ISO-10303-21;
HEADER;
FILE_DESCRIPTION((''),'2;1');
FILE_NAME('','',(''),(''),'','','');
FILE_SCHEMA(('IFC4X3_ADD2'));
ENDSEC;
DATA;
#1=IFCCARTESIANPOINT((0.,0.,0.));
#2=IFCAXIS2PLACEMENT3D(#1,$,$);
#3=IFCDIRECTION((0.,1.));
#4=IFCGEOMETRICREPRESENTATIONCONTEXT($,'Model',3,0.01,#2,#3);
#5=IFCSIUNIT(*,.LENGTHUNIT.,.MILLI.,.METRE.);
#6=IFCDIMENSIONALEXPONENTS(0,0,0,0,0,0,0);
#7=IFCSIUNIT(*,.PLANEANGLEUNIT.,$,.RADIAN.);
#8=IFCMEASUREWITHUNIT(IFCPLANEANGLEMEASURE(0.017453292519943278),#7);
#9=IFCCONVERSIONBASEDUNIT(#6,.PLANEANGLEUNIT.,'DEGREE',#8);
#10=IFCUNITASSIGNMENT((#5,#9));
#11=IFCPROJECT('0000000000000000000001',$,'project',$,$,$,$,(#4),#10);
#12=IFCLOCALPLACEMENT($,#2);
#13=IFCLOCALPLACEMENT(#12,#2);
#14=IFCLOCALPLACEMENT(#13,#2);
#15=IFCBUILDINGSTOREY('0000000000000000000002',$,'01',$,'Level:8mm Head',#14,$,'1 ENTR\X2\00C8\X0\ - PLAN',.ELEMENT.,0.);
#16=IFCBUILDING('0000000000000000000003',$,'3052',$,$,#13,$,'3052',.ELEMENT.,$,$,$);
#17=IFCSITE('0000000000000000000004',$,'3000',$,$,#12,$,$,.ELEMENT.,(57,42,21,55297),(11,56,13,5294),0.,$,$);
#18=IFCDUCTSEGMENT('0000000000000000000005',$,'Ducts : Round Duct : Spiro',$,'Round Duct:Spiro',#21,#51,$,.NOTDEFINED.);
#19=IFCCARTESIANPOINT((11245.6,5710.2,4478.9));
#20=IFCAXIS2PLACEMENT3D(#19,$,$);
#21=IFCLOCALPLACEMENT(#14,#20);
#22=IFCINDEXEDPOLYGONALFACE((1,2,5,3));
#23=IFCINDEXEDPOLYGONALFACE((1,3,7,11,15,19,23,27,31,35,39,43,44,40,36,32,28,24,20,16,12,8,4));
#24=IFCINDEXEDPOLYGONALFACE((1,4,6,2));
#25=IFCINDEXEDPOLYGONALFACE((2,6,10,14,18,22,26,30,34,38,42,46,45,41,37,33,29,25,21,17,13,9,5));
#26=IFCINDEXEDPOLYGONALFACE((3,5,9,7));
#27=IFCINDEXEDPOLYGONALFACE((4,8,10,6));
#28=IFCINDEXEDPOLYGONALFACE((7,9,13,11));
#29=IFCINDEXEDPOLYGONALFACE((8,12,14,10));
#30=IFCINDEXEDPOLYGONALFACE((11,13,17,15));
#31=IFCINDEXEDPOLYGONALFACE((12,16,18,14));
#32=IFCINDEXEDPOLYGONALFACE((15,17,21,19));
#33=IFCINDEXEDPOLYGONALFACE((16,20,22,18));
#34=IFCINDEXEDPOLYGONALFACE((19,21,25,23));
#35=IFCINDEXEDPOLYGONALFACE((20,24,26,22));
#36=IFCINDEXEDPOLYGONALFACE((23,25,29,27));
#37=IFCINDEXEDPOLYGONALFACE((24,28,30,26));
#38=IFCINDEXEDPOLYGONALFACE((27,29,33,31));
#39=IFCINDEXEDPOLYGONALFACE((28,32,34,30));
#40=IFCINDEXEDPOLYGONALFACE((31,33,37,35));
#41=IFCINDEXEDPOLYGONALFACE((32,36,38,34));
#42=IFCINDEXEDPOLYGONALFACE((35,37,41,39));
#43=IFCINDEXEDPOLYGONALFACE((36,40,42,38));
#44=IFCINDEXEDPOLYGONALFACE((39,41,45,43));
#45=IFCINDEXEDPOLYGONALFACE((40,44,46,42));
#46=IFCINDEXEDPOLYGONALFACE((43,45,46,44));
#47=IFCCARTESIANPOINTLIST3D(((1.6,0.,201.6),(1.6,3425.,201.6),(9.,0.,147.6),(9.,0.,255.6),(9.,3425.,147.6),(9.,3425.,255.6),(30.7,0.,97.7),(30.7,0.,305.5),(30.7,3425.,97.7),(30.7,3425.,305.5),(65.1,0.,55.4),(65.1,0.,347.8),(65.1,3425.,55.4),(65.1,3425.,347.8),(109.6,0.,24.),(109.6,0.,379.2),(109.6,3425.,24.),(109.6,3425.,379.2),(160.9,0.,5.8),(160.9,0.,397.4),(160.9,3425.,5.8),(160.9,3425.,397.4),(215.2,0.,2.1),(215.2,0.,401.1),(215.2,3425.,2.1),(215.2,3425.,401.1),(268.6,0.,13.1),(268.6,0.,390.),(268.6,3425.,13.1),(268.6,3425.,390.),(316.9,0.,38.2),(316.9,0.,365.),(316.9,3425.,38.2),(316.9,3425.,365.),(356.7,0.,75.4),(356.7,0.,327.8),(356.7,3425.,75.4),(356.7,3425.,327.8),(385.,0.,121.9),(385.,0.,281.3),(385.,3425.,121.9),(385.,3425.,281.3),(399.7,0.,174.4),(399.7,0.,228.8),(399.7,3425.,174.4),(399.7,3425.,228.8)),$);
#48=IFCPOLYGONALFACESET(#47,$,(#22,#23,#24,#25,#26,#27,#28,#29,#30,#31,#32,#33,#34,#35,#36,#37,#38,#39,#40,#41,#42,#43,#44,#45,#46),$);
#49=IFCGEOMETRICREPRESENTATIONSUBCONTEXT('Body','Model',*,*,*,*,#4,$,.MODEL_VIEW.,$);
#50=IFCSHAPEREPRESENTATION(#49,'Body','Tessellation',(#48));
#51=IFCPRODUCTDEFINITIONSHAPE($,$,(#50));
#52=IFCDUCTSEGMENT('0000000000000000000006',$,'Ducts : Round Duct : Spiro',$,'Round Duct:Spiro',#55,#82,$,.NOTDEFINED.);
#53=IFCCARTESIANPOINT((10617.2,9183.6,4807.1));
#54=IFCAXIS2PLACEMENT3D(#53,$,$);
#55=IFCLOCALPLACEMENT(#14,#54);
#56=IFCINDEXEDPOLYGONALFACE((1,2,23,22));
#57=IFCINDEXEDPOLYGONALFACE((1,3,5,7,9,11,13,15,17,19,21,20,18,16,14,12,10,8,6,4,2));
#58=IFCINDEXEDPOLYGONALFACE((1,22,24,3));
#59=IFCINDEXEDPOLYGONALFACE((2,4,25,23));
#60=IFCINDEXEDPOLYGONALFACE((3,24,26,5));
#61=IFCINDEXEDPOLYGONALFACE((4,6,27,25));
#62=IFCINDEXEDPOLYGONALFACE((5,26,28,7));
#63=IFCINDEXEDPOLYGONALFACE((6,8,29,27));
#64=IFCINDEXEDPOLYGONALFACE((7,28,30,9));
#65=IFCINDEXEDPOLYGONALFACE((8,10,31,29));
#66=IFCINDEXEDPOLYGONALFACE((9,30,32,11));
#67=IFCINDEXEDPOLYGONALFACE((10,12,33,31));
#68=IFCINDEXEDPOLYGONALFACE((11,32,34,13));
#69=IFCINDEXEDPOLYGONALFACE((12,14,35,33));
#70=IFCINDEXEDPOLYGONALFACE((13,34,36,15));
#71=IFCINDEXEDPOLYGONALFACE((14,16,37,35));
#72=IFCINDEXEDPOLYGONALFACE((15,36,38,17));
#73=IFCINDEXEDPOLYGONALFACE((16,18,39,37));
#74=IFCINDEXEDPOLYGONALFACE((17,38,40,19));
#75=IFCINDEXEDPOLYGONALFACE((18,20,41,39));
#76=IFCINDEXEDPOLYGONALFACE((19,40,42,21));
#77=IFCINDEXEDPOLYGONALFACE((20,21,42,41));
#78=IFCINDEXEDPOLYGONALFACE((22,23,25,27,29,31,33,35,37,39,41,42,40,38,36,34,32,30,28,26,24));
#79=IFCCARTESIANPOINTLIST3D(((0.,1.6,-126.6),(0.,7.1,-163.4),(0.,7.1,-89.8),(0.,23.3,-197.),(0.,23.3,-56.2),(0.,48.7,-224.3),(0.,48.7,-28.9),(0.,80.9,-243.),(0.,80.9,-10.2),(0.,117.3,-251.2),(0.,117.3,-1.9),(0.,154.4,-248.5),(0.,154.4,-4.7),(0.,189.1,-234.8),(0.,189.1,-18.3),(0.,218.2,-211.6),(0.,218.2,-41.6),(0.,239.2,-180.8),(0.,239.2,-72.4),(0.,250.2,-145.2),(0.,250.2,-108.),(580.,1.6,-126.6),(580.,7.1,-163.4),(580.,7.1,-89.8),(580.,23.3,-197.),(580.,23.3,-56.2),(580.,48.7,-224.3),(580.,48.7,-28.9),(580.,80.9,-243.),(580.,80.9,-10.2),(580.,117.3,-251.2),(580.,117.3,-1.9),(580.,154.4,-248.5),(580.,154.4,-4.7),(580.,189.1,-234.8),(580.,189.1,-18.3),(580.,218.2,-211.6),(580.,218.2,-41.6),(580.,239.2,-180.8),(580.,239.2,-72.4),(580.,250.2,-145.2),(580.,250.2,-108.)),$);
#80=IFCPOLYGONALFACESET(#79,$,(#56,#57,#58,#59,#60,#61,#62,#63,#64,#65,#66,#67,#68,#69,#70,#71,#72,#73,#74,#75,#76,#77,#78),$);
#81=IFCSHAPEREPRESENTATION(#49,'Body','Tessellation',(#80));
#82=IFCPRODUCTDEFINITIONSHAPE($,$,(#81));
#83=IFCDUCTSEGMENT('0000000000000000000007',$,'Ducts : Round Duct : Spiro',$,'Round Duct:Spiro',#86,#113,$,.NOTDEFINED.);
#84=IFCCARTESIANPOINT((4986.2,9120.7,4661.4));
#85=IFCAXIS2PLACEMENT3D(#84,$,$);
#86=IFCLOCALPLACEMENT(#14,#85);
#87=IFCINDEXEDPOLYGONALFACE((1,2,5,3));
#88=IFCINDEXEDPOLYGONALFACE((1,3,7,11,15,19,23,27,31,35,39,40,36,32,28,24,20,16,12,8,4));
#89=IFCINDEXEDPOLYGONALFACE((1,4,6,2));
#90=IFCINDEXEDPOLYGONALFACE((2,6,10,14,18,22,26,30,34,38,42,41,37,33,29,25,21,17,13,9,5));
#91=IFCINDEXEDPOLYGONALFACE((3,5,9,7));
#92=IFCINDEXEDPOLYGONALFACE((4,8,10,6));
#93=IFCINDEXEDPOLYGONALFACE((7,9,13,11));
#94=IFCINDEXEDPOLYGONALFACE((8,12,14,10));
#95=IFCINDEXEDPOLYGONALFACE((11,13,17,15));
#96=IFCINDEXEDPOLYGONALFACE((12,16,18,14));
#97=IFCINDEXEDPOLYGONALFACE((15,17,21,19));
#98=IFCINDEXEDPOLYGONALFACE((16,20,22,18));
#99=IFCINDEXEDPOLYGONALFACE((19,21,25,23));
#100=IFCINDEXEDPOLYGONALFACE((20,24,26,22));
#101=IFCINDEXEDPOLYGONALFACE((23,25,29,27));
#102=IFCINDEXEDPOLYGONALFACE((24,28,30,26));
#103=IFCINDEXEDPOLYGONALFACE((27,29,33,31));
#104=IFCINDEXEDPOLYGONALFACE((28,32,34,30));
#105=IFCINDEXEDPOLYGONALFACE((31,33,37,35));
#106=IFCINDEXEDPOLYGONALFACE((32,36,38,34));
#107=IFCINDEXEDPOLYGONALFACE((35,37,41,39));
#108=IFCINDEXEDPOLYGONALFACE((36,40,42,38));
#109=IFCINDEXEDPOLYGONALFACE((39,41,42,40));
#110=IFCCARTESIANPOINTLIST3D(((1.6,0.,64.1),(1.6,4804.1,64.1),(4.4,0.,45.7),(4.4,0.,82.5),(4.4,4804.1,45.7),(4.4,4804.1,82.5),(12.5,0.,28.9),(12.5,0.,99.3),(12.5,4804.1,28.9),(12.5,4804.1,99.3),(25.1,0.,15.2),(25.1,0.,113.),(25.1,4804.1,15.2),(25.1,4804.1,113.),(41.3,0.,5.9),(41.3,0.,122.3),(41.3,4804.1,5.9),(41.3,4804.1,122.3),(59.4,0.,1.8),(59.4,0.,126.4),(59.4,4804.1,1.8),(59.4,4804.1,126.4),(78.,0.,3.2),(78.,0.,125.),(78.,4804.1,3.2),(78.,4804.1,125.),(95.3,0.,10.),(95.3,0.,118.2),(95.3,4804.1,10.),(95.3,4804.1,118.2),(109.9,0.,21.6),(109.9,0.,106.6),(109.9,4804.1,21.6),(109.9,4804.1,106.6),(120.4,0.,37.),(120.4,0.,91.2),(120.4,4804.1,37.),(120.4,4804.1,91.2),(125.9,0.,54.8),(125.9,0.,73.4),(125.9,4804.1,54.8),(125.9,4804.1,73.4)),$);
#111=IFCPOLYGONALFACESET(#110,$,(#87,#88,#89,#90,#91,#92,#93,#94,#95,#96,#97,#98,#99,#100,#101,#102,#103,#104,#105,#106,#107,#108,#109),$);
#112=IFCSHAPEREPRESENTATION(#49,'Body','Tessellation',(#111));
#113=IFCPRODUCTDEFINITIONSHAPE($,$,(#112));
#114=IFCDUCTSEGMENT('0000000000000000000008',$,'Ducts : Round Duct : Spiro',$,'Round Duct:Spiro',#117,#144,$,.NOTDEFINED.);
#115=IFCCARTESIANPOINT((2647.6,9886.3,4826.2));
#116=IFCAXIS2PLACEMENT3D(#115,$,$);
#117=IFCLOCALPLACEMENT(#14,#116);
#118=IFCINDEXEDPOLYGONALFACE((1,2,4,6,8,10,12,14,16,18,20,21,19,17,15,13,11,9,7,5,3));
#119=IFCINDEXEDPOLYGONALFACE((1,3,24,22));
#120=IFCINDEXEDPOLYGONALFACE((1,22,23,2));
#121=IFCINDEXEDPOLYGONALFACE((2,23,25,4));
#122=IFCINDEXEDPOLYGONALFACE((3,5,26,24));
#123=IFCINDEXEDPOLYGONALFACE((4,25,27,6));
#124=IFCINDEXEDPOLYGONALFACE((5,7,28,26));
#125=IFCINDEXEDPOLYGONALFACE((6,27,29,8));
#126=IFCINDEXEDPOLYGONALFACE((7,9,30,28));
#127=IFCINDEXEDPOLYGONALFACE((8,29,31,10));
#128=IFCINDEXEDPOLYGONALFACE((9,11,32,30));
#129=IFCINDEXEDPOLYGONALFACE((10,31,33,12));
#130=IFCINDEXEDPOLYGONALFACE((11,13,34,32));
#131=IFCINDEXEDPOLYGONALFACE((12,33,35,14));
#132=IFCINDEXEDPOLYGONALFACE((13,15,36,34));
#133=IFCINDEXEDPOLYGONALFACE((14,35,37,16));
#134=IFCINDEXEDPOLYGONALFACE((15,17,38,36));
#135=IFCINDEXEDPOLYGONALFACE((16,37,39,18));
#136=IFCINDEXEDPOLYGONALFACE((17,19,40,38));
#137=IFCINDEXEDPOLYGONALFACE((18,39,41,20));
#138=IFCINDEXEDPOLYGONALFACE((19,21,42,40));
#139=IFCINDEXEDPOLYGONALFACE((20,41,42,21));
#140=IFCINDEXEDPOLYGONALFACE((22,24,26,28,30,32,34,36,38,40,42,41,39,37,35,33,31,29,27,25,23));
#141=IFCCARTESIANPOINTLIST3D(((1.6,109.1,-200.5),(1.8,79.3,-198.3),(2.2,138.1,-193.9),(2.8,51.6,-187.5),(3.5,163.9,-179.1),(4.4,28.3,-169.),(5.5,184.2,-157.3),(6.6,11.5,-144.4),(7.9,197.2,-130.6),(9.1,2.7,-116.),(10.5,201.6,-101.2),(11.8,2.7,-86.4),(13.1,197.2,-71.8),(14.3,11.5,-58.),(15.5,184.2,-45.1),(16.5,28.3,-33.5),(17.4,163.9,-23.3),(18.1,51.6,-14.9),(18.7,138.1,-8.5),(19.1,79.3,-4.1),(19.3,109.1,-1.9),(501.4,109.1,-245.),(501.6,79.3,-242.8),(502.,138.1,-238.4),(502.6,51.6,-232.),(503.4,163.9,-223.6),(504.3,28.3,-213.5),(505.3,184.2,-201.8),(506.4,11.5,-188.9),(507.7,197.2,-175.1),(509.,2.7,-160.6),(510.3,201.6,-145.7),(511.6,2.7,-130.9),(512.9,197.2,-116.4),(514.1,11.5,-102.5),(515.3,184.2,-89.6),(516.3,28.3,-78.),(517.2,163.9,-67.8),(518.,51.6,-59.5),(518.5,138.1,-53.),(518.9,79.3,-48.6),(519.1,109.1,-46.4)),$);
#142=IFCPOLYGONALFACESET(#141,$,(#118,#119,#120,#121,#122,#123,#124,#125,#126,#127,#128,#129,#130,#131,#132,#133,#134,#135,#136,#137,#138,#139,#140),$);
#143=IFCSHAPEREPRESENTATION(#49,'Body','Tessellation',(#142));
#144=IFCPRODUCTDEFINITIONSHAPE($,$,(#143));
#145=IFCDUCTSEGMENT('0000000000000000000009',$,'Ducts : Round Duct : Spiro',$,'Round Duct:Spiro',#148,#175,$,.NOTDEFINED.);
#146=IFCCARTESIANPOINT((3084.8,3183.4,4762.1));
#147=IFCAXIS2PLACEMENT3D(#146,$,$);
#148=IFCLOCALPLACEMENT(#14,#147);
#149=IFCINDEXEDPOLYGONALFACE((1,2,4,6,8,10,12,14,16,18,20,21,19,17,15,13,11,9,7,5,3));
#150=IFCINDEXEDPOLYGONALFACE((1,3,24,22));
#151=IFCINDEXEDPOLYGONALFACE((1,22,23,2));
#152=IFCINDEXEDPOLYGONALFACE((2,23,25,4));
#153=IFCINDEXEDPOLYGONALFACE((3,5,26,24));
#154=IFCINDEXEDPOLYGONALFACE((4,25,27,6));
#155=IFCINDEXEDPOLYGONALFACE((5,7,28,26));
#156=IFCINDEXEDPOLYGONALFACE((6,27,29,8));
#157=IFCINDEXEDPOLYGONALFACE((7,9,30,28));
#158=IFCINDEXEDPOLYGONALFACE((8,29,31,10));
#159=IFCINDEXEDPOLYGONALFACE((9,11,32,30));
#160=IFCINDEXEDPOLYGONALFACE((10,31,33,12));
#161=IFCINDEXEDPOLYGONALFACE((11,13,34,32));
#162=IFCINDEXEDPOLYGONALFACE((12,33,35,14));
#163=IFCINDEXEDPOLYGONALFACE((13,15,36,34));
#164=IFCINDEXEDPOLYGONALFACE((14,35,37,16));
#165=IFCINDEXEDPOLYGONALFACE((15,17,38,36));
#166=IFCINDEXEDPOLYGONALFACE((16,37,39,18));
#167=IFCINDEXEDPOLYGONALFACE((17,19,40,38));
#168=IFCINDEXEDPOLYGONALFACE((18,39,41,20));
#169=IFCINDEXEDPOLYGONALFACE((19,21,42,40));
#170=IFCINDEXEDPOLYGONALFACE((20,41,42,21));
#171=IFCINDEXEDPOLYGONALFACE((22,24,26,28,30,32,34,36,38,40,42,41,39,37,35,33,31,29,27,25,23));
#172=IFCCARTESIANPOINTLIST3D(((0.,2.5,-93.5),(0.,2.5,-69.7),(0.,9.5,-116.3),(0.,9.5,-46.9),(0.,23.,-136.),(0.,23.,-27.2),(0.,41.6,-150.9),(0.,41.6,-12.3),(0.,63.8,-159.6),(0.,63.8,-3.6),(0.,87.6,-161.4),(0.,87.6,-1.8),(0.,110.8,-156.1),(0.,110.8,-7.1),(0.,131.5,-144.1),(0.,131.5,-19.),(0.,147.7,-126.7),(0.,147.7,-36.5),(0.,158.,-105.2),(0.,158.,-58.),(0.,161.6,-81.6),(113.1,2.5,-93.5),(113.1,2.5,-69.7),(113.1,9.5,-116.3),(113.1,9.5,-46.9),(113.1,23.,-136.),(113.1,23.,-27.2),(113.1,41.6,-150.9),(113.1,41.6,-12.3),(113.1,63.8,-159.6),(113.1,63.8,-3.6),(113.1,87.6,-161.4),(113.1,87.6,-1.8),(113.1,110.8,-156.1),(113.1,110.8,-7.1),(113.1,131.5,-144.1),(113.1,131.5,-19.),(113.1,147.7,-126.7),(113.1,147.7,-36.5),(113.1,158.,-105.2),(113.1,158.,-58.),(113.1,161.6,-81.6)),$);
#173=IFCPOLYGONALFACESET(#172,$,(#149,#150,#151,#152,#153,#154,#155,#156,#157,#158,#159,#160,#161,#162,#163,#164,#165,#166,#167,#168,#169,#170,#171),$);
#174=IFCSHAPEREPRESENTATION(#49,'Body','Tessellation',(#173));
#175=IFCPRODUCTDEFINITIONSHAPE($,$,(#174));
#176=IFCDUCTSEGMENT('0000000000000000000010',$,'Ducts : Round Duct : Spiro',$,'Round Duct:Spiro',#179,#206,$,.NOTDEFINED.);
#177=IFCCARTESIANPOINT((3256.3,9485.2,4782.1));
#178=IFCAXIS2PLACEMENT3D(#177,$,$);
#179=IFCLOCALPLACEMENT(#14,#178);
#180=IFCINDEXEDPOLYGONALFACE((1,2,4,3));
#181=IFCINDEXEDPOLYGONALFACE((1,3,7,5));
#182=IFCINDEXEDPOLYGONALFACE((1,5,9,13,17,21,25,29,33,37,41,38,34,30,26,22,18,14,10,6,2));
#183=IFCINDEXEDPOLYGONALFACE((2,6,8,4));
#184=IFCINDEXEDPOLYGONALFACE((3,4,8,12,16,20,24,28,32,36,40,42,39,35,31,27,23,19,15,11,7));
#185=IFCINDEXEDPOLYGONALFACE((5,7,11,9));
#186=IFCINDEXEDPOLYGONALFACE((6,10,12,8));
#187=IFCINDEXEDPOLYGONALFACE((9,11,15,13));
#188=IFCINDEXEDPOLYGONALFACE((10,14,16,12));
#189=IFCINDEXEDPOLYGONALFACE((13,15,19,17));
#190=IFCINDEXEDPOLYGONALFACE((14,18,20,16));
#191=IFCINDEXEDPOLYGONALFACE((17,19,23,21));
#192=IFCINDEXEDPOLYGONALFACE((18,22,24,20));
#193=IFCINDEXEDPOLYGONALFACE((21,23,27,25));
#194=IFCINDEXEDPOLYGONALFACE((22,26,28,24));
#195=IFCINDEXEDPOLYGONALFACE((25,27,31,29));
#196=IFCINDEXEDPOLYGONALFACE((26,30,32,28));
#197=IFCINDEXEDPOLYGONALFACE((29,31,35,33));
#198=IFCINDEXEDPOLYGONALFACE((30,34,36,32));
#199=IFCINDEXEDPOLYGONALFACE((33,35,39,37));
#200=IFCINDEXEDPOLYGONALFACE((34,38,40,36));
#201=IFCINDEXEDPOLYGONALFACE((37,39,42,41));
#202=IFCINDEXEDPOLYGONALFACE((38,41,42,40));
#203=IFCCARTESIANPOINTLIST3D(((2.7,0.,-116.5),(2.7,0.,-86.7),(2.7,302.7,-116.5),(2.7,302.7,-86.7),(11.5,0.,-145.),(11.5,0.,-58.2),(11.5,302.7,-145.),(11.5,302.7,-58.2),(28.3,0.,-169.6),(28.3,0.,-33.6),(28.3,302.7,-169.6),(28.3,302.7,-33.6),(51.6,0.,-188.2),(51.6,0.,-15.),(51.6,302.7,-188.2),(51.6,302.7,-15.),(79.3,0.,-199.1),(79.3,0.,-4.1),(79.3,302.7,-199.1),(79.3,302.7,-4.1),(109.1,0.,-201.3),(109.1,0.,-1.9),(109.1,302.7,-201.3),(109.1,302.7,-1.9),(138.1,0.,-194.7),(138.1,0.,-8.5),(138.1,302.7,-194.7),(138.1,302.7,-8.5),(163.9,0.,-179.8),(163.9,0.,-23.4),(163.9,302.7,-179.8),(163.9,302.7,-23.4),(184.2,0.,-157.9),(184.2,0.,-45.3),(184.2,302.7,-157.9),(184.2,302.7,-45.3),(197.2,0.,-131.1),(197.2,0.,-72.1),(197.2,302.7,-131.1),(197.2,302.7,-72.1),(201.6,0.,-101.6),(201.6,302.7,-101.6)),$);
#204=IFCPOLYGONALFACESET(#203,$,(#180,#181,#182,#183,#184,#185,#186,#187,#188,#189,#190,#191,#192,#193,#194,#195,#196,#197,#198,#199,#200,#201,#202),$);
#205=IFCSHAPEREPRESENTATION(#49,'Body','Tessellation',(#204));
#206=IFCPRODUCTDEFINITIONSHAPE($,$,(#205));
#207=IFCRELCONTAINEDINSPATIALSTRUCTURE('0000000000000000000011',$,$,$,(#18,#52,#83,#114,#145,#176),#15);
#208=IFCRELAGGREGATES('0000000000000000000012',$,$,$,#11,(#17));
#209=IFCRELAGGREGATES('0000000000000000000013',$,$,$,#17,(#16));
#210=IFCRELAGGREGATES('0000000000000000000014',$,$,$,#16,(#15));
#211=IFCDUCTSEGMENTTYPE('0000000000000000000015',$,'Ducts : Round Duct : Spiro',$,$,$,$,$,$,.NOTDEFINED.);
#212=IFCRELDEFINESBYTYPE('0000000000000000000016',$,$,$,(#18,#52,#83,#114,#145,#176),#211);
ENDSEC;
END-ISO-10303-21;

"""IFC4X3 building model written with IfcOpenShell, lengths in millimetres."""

from ifc_helpers import new_model, entity, si_unit, converted_unit, direction, frame, frame_2d, origin, origin_2d_with_axis, place, context, subcontext, project, spatial, circle, extrude, type_object, element, save


model = new_model("IFC4X3")

# Units and contexts
model_context = context("Model", 3, precision=0.01, world=origin(), true_north=direction((0.0, 1.0)))
body_context = subcontext(model_context, "Body", "Model", "MODEL_VIEW")
ifc_project = project(units=[si_unit("LENGTHUNIT", "METRE", prefix="MILLI"), converted_unit("PLANEANGLEUNIT", "DEGREE", entity("IfcPlaneAngleMeasure", 0.017453292519943278), si_unit("PLANEANGLEUNIT", "RADIAN"), dimensions=[0, 0, 0, 0, 0, 0, 0])], contexts=[model_context])

# Site, building, storey
site_placement = place(None, origin())
site = spatial("IfcSite", under=ifc_project, at=site_placement, Name="3000", CompositionType="ELEMENT", RefLatitude=(57, 42, 21, 55297), RefLongitude=(11, 56, 13, 5294), RefElevation=0.0)
building_placement = place(site_placement, origin())
building = spatial("IfcBuilding", under=site, at=building_placement, Name="3052", LongName="3052", CompositionType="ELEMENT")
storey_placement = place(building_placement, origin())
storey = spatial("IfcBuildingStorey", under=building, at=storey_placement, Name="01", ObjectType="Level:8mm Head", LongName="1 ENTRÈ - PLAN", CompositionType="ELEMENT", Elevation=0.0)

# Duct segments
duct_segment_type = type_object("IfcDuctSegmentType", Name="Ducts : Round Duct : Spiro", PredefinedType="NOTDEFINED")
duct_segment_1_placement = place(storey_placement, frame((11245.6, 5710.2, 4478.9)))
element("IfcDuctSegment", 1, at=duct_segment_1_placement, inside=storey, type_object=duct_segment_type, Name="Ducts : Round Duct : Spiro", ObjectType="Round Duct:Spiro", PredefinedType="NOTDEFINED", context=body_context, shape_type="SweptSolid", body=[
    extrude(circle(Radius=200.0, at=origin_2d_with_axis()), frame((201.6, 0.0, 201.6), z_axis=(0.0, 1.0, 0.0), x_axis=(-1.0, 0.0, 0.0)), (0.0, 0.0, 1.0), 3425.0),
])
duct_segment_2_placement = place(storey_placement, frame((10617.2, 9183.6, 4807.1)))
element("IfcDuctSegment", 2, at=duct_segment_2_placement, inside=storey, type_object=duct_segment_type, Name="Ducts : Round Duct : Spiro", ObjectType="Round Duct:Spiro", PredefinedType="NOTDEFINED", context=body_context, shape_type="SweptSolid", body=[
    extrude(circle(Radius=125.0, at=frame_2d((0.0, 0.0), x_axis=(1.0, 0.0))), frame((0.0, 126.6, -126.6), z_axis=(1.0, 0.0, 0.0), x_axis=(0.0, -1.0, 0.0)), (0.0, 0.0, 1.0), 580.0),
])
duct_segment_3_placement = place(storey_placement, frame((4986.2, 9120.7, 4661.4)))
element("IfcDuctSegment", 3, at=duct_segment_3_placement, inside=storey, type_object=duct_segment_type, Name="Ducts : Round Duct : Spiro", ObjectType="Round Duct:Spiro", PredefinedType="NOTDEFINED", context=body_context, shape_type="SweptSolid", body=[
    extrude(circle(Radius=62.5, at=origin_2d_with_axis()), frame((64.1, 0.0, 64.1), z_axis=(0.0, 1.0, 0.0), x_axis=(-1.0, 0.0, 0.0)), (0.0, 0.0, 1.0), 4804.1),
])
duct_segment_4_placement = place(storey_placement, frame((2647.6, 9886.3, 4826.2)))
element("IfcDuctSegment", 4, at=duct_segment_4_placement, inside=storey, type_object=duct_segment_type, Name="Ducts : Round Duct : Spiro", ObjectType="Round Duct:Spiro", PredefinedType="NOTDEFINED", context=body_context, shape_type="SweptSolid", body=[
    extrude(circle(Radius=100.0, at=frame_2d((0.0, 0.0), x_axis=(1.0, 0.0))), frame((510.3, 101.6, -145.7), z_axis=(-0.996057, 0.0, 0.088711), x_axis=(0.0, 1.0, 0.0)), (0.0, 0.0, 1.0), 501.8),
])
duct_segment_5_placement = place(storey_placement, frame((3084.8, 3183.4, 4762.1)))
element("IfcDuctSegment", 5, at=duct_segment_5_placement, inside=storey, type_object=duct_segment_type, Name="Ducts : Round Duct : Spiro", ObjectType="Round Duct:Spiro", PredefinedType="NOTDEFINED", context=body_context, shape_type="SweptSolid", body=[
    extrude(circle(Radius=80.0, at=frame_2d((0.0, 0.0), x_axis=(1.0, 0.0))), frame((0.0, 81.6, -81.6), z_axis=(1.0, 0.0, 0.0), x_axis=(0.0, 1.0, 0.0)), (0.0, 0.0, 1.0), 113.1),
])
duct_segment_6_placement = place(storey_placement, frame((3256.3, 9485.2, 4782.1)))
element("IfcDuctSegment", 6, at=duct_segment_6_placement, inside=storey, type_object=duct_segment_type, Name="Ducts : Round Duct : Spiro", ObjectType="Round Duct:Spiro", PredefinedType="NOTDEFINED", context=body_context, shape_type="SweptSolid", body=[
    extrude(circle(Radius=100.0, at=frame_2d((0.0, 0.0), x_axis=(1.0, 0.0))), frame((101.6, 0.0, -101.6), z_axis=(0.0, 1.0, 0.0), x_axis=(1.0, 0.0, 0.0)), (0.0, 0.0, 1.0), 302.7),
])

save(model, "model.ifc")
